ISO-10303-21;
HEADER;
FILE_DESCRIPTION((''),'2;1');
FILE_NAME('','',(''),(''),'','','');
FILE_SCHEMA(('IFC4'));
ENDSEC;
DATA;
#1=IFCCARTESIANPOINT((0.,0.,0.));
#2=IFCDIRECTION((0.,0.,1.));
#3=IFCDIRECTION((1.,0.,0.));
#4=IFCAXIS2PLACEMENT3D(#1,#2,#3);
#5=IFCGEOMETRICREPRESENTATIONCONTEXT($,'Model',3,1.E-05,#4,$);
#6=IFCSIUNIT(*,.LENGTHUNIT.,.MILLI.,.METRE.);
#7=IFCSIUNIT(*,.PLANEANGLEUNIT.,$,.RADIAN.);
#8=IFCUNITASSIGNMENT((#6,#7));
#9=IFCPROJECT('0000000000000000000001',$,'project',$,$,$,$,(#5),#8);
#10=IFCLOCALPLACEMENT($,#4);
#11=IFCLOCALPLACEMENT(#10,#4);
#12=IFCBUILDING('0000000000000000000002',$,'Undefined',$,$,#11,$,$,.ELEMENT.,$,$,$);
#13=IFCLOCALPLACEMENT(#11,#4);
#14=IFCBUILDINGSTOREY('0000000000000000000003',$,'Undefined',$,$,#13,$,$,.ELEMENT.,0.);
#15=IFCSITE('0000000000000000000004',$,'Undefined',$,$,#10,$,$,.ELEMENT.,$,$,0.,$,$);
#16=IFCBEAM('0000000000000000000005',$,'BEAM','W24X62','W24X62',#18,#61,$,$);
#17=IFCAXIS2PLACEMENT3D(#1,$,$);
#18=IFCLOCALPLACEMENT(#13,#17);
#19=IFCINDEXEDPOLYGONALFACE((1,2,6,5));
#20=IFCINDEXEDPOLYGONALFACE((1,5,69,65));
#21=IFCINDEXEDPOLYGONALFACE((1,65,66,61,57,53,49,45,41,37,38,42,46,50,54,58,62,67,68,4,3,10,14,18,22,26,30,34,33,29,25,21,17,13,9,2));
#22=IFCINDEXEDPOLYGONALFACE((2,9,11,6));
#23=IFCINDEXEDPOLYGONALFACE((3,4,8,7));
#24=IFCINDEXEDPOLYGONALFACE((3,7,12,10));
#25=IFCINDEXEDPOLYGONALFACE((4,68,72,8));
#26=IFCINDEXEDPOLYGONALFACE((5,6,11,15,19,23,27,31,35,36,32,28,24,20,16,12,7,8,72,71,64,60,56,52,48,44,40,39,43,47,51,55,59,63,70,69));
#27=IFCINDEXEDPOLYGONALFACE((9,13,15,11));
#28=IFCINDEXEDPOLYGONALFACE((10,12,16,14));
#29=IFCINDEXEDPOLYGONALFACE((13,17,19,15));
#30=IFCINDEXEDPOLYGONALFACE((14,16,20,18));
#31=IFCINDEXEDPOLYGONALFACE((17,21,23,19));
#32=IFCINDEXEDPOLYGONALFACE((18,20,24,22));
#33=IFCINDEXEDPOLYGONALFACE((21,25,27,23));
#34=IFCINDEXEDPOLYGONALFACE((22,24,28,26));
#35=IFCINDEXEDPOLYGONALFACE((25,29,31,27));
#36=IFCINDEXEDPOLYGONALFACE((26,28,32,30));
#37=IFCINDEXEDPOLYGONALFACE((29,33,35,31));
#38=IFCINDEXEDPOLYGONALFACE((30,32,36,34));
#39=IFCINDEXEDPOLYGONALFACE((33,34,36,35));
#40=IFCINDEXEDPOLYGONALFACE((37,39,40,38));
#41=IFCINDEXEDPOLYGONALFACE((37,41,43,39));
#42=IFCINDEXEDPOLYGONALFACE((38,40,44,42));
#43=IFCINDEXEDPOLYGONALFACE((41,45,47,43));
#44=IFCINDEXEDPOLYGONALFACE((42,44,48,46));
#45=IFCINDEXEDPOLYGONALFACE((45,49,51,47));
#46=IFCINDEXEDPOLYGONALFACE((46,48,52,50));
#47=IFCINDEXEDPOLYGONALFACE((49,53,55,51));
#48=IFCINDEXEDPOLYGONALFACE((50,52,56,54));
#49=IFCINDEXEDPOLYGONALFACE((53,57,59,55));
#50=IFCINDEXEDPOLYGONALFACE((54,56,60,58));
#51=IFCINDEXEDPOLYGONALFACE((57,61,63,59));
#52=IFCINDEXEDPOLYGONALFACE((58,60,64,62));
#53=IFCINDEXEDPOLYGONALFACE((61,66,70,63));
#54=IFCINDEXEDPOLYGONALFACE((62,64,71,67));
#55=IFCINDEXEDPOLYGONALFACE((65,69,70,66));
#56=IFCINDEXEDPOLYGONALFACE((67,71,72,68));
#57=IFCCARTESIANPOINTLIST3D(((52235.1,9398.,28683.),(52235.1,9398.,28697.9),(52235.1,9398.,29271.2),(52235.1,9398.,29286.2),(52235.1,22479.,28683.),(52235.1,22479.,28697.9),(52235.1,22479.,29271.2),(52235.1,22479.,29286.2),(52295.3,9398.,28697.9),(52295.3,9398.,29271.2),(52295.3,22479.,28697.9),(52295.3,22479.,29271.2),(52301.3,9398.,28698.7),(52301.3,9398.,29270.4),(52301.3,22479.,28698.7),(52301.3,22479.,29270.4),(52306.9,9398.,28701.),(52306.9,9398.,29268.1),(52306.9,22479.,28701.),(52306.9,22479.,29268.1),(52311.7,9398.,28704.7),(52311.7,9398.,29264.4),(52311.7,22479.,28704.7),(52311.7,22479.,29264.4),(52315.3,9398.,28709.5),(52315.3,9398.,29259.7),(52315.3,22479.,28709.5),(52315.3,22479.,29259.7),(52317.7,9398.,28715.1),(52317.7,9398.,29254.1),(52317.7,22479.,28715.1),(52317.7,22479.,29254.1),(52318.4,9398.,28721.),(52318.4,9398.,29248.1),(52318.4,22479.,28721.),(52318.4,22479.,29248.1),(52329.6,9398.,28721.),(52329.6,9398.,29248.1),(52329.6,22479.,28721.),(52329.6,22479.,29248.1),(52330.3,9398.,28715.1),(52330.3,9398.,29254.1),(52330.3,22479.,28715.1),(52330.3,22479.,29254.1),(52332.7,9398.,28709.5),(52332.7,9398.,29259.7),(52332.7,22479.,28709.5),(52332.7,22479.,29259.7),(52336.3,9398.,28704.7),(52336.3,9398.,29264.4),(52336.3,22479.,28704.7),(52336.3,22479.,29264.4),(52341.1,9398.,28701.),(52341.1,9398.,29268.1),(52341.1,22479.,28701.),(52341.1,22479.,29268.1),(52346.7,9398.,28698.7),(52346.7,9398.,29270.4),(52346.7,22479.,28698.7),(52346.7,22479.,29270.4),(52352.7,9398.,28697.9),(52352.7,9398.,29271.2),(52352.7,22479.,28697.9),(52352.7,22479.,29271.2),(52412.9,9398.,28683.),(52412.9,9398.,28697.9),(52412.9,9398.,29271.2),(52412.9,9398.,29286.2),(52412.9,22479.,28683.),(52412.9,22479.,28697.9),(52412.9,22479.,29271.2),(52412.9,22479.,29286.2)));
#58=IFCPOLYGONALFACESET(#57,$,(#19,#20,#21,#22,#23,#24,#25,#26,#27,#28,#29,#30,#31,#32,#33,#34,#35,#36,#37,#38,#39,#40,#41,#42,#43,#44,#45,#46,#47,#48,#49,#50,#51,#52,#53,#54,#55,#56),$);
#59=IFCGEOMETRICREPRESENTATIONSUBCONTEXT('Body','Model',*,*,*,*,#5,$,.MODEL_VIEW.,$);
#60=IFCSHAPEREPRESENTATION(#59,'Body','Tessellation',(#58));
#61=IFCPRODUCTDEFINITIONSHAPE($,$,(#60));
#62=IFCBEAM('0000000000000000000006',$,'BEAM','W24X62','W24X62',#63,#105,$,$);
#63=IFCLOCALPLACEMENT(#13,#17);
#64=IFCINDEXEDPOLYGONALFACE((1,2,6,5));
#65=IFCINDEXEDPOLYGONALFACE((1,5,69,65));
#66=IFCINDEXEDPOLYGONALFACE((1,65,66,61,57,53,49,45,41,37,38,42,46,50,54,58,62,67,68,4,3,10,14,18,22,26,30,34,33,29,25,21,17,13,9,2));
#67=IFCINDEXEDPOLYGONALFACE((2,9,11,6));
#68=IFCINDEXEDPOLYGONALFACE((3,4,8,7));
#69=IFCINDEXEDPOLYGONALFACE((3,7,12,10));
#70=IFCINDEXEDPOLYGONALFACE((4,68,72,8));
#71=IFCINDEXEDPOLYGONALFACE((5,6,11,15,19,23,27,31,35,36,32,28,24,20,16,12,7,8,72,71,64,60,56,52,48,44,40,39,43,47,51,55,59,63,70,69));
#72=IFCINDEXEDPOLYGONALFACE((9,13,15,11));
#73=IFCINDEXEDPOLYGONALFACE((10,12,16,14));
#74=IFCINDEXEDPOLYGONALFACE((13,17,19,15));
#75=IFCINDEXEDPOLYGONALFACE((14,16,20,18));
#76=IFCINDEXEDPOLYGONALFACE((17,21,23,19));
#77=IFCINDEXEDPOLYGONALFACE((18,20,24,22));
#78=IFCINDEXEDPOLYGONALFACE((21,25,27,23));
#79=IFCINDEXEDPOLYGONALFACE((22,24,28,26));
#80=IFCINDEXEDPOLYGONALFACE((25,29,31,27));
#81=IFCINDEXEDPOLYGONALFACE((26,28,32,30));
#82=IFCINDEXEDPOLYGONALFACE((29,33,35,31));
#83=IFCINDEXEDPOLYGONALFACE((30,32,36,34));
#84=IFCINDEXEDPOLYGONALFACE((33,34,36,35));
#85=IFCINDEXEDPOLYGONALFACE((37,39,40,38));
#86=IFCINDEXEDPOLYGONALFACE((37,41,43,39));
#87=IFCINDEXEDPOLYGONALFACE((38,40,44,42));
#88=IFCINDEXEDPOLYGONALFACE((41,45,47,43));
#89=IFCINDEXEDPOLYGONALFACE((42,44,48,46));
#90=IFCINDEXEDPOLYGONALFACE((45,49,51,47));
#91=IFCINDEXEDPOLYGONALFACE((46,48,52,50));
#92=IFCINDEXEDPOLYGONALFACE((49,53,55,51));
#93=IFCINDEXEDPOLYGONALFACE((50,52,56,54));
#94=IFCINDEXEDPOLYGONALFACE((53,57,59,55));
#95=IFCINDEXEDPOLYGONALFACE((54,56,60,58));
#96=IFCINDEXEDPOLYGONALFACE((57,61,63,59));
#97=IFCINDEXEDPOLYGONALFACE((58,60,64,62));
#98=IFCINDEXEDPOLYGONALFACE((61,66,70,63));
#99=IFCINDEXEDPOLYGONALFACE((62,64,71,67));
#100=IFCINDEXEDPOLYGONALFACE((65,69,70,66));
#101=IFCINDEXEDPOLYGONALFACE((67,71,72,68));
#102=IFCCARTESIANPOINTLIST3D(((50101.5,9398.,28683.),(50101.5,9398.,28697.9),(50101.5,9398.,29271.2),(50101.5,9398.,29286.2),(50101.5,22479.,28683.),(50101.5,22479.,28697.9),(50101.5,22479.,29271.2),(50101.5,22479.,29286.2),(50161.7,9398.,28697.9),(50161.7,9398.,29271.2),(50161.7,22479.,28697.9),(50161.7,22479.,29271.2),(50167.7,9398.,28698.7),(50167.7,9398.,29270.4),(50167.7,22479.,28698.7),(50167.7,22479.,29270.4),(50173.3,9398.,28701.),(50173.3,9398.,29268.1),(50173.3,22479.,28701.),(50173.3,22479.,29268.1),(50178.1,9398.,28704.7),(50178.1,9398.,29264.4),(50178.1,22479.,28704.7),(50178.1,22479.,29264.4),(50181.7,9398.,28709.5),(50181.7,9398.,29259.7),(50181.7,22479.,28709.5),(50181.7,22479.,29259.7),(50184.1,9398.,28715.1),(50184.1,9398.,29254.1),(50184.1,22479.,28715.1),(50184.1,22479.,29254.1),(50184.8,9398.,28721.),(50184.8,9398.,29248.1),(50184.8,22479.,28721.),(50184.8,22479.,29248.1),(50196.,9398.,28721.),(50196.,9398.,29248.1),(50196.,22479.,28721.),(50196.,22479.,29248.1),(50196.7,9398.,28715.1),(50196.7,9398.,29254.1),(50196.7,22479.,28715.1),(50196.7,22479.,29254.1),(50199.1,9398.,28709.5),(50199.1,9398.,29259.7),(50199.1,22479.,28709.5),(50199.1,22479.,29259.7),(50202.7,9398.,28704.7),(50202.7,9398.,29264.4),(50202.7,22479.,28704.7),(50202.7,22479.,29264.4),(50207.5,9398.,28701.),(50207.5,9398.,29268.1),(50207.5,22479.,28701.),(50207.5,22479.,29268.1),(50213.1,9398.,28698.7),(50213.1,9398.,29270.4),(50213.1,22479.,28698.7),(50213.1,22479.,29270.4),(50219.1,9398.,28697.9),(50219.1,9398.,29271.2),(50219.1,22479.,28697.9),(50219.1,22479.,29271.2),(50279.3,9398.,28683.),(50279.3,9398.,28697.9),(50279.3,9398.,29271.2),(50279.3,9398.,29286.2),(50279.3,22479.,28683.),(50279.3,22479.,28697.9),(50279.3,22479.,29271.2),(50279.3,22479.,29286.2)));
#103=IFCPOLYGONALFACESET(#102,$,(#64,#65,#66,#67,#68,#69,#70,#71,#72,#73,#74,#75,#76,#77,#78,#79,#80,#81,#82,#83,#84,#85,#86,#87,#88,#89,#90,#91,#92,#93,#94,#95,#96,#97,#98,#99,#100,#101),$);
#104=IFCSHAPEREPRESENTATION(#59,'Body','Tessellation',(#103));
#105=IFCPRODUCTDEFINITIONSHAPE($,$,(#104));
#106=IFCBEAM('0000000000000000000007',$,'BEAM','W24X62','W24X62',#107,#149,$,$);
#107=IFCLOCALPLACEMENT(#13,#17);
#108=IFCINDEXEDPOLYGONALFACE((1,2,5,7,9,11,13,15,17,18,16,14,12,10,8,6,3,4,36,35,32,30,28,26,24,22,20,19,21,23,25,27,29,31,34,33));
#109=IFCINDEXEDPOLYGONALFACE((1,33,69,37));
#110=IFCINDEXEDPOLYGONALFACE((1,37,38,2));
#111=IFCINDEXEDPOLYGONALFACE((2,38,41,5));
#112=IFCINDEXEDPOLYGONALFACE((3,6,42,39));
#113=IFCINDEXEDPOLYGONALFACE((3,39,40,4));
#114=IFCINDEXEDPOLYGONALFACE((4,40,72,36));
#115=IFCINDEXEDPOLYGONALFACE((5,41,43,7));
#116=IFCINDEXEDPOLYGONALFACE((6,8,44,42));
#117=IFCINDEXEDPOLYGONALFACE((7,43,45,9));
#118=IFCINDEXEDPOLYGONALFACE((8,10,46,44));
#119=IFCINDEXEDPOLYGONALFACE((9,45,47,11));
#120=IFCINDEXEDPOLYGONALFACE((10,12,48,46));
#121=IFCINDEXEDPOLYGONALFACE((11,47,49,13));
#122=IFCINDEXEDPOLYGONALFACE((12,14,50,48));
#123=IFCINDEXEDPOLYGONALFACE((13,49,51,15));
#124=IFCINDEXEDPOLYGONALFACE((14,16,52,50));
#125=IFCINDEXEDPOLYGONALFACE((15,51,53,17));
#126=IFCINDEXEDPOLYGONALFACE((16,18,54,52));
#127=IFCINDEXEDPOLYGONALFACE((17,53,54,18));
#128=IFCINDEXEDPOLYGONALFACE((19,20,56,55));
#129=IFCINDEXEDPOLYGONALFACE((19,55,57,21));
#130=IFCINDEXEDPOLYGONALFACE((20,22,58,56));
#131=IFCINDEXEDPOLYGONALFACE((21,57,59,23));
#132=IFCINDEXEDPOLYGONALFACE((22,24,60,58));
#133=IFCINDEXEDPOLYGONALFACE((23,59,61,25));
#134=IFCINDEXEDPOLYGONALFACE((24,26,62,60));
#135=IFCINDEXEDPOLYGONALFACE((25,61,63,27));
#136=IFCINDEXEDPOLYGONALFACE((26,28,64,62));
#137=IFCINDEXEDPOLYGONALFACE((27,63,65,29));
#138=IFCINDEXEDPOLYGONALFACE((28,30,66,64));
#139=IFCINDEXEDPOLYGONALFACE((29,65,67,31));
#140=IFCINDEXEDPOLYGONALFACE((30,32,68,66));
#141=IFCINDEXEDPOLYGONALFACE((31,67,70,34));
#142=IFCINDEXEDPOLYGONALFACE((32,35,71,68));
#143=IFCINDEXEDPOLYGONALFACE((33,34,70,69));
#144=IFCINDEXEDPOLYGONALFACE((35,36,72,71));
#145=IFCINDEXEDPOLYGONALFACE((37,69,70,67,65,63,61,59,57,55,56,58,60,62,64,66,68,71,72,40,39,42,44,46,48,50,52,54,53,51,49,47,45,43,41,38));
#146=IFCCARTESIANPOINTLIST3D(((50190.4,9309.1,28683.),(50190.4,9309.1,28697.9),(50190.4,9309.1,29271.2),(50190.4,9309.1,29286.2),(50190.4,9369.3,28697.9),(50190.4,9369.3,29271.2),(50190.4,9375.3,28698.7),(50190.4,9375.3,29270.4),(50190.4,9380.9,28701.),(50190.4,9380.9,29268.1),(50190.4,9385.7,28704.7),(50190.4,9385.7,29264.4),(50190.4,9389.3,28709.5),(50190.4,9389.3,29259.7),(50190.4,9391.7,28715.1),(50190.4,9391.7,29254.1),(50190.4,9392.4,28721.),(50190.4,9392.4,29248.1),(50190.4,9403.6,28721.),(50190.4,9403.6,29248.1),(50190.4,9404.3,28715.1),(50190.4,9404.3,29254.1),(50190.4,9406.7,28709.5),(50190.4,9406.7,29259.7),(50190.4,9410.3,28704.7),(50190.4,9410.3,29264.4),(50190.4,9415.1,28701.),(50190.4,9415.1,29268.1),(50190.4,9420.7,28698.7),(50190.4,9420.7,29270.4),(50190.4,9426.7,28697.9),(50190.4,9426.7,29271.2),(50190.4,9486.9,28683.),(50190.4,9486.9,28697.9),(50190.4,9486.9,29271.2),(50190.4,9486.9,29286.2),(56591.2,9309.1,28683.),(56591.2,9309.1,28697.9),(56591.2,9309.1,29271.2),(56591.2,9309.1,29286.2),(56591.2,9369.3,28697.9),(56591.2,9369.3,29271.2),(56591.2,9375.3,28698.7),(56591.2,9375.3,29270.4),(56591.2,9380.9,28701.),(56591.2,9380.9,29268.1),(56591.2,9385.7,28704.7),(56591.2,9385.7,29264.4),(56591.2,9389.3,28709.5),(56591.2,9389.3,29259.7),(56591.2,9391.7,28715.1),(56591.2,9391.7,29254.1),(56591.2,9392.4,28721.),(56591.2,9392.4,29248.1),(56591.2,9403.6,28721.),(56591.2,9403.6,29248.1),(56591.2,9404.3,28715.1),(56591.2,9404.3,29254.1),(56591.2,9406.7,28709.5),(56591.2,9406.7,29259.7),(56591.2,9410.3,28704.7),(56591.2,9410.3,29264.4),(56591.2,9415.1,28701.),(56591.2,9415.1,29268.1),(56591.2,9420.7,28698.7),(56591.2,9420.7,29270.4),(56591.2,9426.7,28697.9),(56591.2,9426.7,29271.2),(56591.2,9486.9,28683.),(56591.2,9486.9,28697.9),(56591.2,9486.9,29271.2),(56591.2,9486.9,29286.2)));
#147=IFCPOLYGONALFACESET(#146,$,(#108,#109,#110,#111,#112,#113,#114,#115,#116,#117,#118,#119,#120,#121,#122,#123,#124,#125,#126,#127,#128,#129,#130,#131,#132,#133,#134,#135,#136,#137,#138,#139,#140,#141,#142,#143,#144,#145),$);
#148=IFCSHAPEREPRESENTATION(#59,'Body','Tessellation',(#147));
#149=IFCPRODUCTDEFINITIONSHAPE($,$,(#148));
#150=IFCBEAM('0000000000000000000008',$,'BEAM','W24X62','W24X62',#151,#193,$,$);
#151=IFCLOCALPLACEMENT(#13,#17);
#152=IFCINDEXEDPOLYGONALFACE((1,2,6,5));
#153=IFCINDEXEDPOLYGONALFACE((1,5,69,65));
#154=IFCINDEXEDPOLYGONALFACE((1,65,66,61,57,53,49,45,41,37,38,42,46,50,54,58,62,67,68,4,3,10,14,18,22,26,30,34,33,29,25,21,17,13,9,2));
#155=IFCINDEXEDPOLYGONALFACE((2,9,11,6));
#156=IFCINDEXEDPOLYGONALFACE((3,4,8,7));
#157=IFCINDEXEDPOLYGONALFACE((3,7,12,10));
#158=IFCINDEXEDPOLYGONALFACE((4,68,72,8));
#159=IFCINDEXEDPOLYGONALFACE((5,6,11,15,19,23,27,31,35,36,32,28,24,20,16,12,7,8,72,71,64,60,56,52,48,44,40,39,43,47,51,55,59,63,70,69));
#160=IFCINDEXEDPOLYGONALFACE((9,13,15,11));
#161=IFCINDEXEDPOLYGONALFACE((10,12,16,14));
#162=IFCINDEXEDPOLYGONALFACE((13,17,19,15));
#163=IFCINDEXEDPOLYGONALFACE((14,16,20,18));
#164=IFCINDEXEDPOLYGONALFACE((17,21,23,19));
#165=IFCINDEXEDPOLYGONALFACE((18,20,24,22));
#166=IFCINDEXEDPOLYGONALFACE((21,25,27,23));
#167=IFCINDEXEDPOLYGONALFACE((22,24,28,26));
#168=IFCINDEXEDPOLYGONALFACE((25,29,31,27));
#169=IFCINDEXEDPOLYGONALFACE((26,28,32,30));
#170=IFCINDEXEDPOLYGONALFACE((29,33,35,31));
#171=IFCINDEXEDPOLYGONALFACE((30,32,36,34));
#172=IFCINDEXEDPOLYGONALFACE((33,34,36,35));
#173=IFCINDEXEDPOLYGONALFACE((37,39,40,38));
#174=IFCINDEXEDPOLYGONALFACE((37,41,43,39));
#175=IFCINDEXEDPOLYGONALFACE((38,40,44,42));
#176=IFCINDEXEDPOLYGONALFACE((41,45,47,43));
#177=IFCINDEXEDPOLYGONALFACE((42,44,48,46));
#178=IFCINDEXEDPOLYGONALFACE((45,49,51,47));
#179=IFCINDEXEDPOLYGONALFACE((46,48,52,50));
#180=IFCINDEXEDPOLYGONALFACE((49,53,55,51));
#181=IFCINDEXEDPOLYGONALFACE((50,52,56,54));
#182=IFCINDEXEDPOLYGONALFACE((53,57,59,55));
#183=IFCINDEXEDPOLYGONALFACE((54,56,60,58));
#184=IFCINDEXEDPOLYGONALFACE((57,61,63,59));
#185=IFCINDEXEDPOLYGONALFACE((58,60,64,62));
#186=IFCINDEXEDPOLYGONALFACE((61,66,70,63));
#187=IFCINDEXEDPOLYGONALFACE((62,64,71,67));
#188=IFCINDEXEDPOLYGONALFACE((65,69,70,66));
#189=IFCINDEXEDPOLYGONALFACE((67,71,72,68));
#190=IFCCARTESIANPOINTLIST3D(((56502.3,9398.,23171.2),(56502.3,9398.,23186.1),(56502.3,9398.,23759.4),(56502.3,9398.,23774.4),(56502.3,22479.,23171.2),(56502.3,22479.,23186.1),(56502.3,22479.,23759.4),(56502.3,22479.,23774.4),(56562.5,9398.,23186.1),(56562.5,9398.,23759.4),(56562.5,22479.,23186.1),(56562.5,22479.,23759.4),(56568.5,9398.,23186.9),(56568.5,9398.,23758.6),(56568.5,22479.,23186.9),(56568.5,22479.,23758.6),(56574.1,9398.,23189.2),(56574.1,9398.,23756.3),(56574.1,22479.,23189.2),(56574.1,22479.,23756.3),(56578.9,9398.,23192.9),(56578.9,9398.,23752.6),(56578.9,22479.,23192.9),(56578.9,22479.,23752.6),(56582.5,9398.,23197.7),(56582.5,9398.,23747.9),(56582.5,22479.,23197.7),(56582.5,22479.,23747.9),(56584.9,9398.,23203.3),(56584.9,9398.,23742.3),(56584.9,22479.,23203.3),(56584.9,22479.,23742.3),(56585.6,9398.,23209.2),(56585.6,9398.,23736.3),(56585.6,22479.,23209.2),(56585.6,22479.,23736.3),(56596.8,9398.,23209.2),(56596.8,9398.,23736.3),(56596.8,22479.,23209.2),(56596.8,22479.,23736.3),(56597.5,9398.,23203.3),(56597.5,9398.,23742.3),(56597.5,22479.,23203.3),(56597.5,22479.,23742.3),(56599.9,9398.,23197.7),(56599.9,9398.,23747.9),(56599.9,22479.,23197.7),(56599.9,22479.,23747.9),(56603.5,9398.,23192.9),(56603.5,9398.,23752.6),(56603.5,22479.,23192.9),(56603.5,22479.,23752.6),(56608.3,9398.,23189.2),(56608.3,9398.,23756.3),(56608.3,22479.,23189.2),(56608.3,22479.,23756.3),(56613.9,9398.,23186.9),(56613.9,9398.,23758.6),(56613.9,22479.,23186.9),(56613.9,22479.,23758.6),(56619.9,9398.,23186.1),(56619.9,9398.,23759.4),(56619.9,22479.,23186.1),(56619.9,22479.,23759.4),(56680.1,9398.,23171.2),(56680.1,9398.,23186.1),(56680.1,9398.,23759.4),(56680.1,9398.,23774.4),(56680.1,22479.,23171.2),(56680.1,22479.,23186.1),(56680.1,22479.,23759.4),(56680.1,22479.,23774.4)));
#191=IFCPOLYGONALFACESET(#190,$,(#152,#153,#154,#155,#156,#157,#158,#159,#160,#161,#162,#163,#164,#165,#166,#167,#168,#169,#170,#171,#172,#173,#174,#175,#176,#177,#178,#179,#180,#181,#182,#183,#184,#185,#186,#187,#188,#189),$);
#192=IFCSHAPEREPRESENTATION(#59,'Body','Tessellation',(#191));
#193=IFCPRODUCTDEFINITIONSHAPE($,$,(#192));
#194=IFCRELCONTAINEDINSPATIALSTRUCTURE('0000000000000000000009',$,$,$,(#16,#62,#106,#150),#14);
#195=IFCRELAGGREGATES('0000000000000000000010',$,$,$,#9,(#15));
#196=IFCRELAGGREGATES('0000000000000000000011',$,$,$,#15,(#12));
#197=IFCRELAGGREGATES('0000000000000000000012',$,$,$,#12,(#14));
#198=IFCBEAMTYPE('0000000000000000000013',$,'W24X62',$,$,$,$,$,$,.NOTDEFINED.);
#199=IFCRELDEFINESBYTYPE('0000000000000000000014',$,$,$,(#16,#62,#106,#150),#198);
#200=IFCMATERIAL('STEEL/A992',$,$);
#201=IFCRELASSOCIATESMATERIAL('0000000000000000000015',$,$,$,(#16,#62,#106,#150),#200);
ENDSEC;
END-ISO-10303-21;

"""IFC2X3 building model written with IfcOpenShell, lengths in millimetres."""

from ifc_helpers import new_model, si_unit, frame, origin_with_axes, origin_2d_with_axis, place, context, subcontext, project, spatial, i_section, extrude, material, type_object, element, save


model = new_model("IFC2X3")

# Units and contexts
model_context = context("Model", 3, precision=1e-05, world=origin_with_axes())
body_context = subcontext(model_context, "Body", "Model", "MODEL_VIEW")
ifc_project = project(units=[si_unit("LENGTHUNIT", "METRE", prefix="MILLI"), si_unit("PLANEANGLEUNIT", "RADIAN")], contexts=[model_context])

# Site, building, storey
site_placement = place(None, origin_with_axes())
site = spatial("IfcSite", under=ifc_project, at=site_placement, Name="Undefined", CompositionType="ELEMENT", RefElevation=0.0)
building_placement = place(site_placement, origin_with_axes())
building = spatial("IfcBuilding", under=site, at=building_placement, Name="Undefined", CompositionType="ELEMENT")
storey_placement = place(building_placement, origin_with_axes())
storey = spatial("IfcBuildingStorey", under=building, at=storey_placement, Name="Undefined", CompositionType="ELEMENT", Elevation=0.0)

# Shared definitions
ifc_material_1 = material(Name="STEEL/A992")

# Beams
beam_type_1 = type_object("IfcBeamType", Name="W24X62", PredefinedType="NOTDEFINED")
for number, where, z_axis, x_axis, name in (
    (1, (52324.0, 9398.0, 28984.6), (0.0, 0.0, 1.0), (0.0, 1.0, 0.0), "BEAM"),
    (2, (50190.4, 9398.0, 28984.6), (0.0, 0.0, 1.0), (0.0, 1.0, 0.0), "BEAM"),
):
    element("IfcBeam", number, at=place(storey_placement, frame(where, z_axis=z_axis, x_axis=x_axis)), inside=storey, type_object=beam_type_1, material=ifc_material_1, Name=name, Description="W24X62", ObjectType="W24X62", context=body_context, shape_type="SweptSolid", body=[
        extrude(i_section(OverallWidth=177.8, OverallDepth=603.2, WebThickness=11.1, FlangeThickness=15.0, FilletRadius=23.1, at=origin_2d_with_axis()), frame((13081.0, 0.0, 0.0), z_axis=(-1.0, 0.0, 0.0), x_axis=(0.0, -1.0, 0.0)), (0.0, 0.0, 1.0), 13081.0),
    ])
beam_1_placement = place(storey_placement, frame((50190.4, 9398.0, 28984.6), z_axis=(0.0, 0.0, 1.0), x_axis=(1.0, 0.0, 0.0)))
element("IfcBeam", 3, at=beam_1_placement, inside=storey, type_object=beam_type_1, material=ifc_material_1, Name="BEAM", Description="W24X62", ObjectType="W24X62", context=body_context, shape_type="SweptSolid", body=[
    extrude(i_section(OverallWidth=177.8, OverallDepth=603.2, WebThickness=11.1, FlangeThickness=15.0, FilletRadius=23.1, at=origin_2d_with_axis()), frame((6400.8, 0.0, 0.0), z_axis=(-1.0, 0.0, 0.0), x_axis=(0.0, -1.0, 0.0)), (0.0, 0.0, 1.0), 6400.8),
])
for number, where, z_axis, x_axis, name in (
    (4, (56591.2, 9398.0, 23472.8), (0.0, 0.0, 1.0), (0.0, 1.0, 0.0), "BEAM"),
):
    element("IfcBeam", number, at=place(storey_placement, frame(where, z_axis=z_axis, x_axis=x_axis)), inside=storey, type_object=beam_type_1, material=ifc_material_1, Name=name, Description="W24X62", ObjectType="W24X62", context=body_context, shape_type="SweptSolid", body=[
        extrude(i_section(OverallWidth=177.8, OverallDepth=603.2, WebThickness=11.1, FlangeThickness=15.0, FilletRadius=23.1, at=origin_2d_with_axis()), frame((13081.0, 0.0, 0.0), z_axis=(-1.0, 0.0, 0.0), x_axis=(0.0, -1.0, 0.0)), (0.0, 0.0, 1.0), 13081.0),
    ])

save(model, "model.ifc")
